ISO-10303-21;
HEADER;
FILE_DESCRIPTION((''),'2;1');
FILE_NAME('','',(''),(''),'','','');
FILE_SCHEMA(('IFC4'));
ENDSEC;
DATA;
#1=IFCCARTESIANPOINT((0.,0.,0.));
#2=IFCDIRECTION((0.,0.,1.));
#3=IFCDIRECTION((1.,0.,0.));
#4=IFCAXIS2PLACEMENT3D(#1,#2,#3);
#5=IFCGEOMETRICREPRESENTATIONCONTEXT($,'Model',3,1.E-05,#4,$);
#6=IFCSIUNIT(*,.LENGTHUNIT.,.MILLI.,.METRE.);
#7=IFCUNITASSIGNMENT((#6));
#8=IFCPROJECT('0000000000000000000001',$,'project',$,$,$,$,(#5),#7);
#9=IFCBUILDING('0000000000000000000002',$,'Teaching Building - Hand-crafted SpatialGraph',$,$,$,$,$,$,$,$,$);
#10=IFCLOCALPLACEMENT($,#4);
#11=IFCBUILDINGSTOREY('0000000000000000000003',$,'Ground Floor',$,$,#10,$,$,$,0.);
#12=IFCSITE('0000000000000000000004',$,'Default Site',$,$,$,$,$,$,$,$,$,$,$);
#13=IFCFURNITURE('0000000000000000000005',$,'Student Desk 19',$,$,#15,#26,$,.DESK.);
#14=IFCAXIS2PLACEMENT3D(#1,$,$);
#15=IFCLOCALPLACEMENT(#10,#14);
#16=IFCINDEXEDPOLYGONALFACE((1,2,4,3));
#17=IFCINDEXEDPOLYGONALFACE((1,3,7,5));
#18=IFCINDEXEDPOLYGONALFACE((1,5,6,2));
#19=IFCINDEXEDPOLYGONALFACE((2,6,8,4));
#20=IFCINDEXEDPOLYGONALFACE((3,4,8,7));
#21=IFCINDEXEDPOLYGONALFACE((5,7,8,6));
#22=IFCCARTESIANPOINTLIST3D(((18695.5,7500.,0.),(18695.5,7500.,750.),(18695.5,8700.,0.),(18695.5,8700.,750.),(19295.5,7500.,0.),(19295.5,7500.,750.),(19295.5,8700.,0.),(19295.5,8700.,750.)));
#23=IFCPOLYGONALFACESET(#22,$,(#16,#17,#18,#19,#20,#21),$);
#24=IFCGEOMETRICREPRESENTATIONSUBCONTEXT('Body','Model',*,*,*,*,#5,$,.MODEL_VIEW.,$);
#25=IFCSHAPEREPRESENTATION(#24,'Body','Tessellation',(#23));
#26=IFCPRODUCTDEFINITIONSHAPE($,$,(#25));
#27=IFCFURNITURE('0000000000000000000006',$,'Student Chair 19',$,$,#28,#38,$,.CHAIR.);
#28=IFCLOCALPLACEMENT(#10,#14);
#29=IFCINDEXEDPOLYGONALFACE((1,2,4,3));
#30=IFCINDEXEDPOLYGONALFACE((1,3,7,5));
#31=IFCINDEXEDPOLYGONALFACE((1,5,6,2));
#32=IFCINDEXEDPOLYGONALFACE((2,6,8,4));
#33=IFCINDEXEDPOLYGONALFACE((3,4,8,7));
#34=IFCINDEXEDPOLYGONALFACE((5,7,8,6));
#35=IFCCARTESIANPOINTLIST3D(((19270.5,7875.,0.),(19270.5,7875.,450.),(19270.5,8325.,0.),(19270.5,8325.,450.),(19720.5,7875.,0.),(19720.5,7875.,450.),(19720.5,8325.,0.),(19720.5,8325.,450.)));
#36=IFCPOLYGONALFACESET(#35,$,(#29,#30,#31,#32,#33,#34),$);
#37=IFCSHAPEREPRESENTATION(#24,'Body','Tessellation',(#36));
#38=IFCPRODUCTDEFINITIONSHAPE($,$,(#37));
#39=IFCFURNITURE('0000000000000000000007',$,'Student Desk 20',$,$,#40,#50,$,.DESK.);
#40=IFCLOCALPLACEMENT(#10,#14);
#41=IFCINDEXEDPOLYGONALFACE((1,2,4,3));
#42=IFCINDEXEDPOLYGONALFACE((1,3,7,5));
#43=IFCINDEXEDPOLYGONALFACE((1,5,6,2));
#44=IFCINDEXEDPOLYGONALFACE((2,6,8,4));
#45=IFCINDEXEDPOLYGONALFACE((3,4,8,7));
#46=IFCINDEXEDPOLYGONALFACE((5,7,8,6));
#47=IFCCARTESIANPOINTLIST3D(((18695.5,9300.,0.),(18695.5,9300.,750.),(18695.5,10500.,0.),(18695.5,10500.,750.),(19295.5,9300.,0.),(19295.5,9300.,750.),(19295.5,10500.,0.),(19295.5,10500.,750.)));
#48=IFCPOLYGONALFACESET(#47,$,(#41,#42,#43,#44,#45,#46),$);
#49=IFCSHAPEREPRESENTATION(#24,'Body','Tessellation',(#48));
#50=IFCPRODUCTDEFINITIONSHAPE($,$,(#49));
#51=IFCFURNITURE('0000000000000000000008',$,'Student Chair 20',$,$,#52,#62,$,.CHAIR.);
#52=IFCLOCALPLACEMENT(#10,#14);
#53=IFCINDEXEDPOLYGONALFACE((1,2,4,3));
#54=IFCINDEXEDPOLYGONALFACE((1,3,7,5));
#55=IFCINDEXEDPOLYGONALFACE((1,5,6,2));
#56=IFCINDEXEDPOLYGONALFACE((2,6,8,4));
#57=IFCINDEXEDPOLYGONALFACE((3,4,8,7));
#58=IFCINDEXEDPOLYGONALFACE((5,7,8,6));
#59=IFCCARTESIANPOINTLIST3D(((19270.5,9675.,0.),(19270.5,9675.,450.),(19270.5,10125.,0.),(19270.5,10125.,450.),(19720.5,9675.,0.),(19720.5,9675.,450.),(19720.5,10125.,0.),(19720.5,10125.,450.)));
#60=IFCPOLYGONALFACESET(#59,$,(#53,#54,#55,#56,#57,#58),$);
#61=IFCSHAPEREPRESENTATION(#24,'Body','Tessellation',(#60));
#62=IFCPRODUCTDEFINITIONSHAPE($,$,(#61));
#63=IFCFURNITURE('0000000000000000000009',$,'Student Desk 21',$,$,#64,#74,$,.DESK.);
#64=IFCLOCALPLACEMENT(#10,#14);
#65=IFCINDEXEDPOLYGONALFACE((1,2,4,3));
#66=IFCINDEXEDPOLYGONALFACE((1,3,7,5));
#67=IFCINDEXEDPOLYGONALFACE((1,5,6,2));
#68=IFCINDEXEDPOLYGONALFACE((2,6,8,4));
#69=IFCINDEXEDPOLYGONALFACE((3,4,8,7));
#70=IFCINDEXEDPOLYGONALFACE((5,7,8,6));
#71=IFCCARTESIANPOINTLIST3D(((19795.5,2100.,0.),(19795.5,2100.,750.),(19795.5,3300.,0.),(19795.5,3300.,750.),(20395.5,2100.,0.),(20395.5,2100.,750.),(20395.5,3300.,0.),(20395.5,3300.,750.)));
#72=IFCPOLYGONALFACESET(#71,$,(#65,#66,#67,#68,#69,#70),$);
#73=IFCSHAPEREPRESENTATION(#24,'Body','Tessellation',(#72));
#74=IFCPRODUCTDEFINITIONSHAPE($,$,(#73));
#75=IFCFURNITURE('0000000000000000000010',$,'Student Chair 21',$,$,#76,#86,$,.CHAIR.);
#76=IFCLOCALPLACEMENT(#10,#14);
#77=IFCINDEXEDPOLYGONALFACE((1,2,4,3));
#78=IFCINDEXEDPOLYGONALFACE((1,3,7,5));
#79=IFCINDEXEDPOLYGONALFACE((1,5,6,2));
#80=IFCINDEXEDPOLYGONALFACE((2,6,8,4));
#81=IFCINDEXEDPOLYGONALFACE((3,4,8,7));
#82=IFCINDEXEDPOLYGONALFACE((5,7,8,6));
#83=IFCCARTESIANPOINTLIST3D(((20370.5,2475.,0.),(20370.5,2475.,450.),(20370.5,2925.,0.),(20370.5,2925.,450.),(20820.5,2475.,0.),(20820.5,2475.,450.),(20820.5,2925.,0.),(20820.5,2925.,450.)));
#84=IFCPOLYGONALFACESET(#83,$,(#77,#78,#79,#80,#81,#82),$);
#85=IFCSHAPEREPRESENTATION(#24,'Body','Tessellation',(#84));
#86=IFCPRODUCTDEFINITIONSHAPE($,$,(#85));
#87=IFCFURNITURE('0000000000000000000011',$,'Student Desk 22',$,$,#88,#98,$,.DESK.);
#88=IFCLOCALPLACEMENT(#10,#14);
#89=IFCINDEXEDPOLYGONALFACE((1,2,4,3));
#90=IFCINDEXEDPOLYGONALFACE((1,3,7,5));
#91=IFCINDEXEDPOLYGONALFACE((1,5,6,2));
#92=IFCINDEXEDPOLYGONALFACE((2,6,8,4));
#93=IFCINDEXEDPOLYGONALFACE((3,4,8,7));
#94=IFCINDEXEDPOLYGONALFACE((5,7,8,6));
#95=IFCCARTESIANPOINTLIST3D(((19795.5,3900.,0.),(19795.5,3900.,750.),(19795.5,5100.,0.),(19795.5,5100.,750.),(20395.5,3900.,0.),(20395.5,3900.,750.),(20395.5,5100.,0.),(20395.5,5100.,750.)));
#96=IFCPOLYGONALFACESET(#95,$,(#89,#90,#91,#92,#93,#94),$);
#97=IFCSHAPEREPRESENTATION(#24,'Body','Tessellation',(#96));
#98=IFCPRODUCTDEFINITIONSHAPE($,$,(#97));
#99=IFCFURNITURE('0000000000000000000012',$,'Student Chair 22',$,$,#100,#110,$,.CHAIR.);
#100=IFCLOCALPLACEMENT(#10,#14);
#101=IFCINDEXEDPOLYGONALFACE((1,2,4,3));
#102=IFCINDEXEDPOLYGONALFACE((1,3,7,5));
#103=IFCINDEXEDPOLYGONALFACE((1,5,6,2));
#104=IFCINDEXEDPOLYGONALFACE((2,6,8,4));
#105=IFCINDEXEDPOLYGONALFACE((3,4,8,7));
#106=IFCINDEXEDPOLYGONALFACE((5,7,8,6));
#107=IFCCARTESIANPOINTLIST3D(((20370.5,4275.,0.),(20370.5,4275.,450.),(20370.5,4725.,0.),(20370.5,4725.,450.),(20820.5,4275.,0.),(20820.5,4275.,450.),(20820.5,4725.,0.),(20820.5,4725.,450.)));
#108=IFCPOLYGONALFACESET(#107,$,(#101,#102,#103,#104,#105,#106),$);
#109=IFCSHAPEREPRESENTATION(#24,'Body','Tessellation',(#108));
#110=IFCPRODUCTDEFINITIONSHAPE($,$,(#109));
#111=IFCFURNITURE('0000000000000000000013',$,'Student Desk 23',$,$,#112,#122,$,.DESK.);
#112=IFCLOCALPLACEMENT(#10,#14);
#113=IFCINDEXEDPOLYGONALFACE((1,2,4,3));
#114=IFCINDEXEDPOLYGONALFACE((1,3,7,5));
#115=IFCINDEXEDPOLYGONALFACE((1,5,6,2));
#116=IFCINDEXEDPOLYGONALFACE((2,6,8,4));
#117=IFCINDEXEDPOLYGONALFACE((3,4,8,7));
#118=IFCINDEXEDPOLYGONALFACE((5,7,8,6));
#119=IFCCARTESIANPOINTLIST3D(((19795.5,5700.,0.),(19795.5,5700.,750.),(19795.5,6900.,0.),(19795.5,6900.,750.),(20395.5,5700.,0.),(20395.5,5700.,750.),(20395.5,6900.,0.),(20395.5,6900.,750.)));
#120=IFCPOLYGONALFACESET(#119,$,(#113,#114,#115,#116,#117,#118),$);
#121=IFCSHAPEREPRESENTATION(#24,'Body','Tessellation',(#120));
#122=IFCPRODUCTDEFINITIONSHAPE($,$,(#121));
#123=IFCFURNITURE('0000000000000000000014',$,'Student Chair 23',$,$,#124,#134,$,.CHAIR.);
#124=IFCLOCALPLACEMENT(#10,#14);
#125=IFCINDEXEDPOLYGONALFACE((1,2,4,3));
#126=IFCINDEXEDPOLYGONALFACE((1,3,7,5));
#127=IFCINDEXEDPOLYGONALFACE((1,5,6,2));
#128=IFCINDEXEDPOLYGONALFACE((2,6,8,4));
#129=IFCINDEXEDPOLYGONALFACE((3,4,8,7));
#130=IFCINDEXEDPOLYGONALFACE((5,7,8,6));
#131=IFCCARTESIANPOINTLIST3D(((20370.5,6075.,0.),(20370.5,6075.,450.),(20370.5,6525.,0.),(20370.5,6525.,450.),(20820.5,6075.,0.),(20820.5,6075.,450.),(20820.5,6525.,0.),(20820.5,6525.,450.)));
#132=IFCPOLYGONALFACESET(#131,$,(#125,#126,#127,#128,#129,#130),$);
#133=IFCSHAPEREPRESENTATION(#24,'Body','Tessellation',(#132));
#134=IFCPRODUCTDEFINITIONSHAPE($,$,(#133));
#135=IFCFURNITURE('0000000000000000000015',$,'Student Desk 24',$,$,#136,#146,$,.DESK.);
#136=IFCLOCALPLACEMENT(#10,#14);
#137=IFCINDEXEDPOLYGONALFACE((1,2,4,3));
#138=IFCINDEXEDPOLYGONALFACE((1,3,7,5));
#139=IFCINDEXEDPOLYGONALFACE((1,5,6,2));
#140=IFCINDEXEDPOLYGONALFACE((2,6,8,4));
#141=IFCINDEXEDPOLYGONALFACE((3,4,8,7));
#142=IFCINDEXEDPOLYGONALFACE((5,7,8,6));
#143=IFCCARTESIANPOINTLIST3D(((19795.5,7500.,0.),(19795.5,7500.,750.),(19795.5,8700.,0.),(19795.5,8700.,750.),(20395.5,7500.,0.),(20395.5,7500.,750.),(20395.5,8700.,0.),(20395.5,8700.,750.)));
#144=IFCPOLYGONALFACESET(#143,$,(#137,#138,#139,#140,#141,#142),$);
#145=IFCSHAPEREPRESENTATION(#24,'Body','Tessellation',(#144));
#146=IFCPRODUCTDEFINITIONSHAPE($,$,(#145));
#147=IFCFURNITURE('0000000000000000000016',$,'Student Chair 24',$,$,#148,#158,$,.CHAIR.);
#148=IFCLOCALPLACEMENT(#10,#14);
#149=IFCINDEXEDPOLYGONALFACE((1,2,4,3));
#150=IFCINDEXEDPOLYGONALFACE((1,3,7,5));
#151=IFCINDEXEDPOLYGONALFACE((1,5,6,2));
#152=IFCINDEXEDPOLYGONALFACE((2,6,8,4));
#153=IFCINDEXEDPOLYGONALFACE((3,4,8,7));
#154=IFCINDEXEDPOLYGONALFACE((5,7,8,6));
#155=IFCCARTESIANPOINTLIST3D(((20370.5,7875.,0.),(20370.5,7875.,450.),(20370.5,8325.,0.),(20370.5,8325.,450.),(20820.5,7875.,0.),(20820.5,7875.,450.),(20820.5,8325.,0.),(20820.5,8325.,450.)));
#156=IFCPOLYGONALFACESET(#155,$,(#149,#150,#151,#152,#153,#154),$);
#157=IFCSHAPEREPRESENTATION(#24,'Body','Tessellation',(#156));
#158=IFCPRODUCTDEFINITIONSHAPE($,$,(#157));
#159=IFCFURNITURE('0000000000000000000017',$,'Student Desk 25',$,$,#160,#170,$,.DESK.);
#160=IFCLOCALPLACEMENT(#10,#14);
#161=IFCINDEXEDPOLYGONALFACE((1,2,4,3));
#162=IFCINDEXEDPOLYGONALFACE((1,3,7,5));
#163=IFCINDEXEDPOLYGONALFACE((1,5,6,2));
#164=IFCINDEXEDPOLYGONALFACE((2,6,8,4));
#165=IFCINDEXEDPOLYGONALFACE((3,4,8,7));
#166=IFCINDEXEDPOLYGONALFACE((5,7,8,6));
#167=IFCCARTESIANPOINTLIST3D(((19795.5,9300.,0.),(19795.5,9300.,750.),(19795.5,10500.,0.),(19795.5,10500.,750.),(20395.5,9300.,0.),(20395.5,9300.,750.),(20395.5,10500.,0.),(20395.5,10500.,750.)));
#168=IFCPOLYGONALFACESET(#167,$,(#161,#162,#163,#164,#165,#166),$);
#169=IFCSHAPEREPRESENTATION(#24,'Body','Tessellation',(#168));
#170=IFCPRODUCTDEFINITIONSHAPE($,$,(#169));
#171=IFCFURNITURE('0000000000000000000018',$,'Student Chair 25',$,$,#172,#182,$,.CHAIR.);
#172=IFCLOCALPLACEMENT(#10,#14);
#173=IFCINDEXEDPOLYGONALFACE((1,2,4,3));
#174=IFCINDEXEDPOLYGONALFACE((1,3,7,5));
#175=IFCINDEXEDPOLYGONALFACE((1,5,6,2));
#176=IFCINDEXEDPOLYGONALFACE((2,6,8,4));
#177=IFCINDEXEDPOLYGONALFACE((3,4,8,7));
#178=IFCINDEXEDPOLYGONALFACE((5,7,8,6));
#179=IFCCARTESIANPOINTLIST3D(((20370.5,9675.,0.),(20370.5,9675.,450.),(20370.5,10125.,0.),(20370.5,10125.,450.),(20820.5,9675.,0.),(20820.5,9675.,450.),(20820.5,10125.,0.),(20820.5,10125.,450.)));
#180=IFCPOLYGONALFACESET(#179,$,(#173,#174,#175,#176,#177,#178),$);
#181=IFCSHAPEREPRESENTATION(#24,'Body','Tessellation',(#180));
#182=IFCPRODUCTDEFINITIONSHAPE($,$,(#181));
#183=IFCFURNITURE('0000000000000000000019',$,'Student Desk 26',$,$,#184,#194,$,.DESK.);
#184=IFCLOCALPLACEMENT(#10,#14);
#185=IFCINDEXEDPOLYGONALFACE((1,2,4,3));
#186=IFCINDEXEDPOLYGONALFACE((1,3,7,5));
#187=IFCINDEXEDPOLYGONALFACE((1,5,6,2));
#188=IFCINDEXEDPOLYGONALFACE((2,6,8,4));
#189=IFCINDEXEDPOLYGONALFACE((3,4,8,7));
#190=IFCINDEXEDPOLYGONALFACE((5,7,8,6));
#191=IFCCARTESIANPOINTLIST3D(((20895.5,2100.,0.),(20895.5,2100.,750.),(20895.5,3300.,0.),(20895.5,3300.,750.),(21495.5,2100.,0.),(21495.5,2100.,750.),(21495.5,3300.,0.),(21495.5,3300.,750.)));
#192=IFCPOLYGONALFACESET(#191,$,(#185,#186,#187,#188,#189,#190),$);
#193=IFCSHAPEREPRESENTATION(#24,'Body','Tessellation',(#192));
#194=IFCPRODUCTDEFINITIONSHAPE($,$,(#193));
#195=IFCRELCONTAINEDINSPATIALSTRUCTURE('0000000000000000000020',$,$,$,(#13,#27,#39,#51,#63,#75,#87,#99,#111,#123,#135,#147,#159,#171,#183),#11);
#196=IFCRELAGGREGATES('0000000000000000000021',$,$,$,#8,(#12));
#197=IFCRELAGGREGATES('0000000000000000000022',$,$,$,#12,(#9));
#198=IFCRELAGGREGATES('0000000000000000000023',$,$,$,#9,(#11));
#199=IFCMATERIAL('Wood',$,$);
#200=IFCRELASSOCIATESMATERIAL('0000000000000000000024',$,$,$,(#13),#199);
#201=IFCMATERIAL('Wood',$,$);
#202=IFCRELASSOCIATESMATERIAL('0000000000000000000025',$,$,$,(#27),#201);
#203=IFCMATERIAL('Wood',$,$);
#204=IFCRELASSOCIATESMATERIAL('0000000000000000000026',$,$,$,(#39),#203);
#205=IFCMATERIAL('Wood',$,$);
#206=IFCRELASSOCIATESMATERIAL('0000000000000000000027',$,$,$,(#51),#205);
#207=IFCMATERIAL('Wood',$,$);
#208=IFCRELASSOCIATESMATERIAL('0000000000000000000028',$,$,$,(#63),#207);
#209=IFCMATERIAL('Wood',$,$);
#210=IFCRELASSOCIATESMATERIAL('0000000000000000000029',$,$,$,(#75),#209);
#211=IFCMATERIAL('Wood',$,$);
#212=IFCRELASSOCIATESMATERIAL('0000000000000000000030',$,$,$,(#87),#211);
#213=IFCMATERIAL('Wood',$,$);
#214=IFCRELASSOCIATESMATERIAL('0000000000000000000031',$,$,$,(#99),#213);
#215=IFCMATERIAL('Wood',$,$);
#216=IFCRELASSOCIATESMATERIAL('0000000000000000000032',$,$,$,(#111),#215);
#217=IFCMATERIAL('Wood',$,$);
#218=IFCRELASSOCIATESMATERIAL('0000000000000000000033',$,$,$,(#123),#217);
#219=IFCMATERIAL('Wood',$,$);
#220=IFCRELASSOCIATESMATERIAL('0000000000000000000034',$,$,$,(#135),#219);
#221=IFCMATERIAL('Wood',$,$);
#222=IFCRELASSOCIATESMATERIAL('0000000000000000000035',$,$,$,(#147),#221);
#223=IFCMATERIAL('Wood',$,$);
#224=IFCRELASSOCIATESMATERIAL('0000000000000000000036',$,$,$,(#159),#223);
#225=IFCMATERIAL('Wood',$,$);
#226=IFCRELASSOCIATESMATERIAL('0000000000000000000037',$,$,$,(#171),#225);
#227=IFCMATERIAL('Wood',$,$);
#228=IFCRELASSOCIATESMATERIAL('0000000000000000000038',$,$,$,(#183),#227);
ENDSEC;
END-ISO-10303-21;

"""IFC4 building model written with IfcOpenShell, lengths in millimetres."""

from ifc_helpers import new_model, si_unit, frame, origin_with_axes, origin_2d, place, context, subcontext, project, spatial, rectangle, extrude, material, element, save


model = new_model("IFC4")

# Units and contexts
model_context = context("Model", 3, precision=1e-05, world=origin_with_axes())
body_context = subcontext(model_context, "Body", "Model", "MODEL_VIEW")
ifc_project = project(units=[si_unit("LENGTHUNIT", "METRE", prefix="MILLI")], contexts=[model_context])

# Site, building, storey
site = spatial("IfcSite", under=ifc_project, Name="Default Site")
building = spatial("IfcBuilding", under=site, Name="Teaching Building - Hand-crafted SpatialGraph")
storey_placement = place(None, origin_with_axes())
storey = spatial("IfcBuildingStorey", under=building, at=storey_placement, Name="Ground Floor", Elevation=0.0)

# Furniture
ifc_material_1 = material(Name="Wood")
furniture_1_placement = place(storey_placement, frame((18995.5, 8100.0, 0.0), z_axis=(0.0, 0.0, 1.0), x_axis=(0.0, 1.0, 0.0)))
element("IfcFurniture", 1, at=furniture_1_placement, inside=storey, material=ifc_material_1, Name="Student Desk 19", PredefinedType="DESK", context=body_context, shape_type="SweptSolid", body=[
    extrude(rectangle(XDim=1200.0, YDim=600.0, at=origin_2d()), origin_with_axes(), (0.0, 0.0, 1.0), 750.0),
])
ifc_material_2 = material(Name="Wood")
furniture_2_placement = place(storey_placement, frame((19495.5, 8100.0, 0.0), z_axis=(0.0, 0.0, 1.0), x_axis=(1.0, 0.0, 0.0)))
element("IfcFurniture", 2, at=furniture_2_placement, inside=storey, material=ifc_material_2, Name="Student Chair 19", PredefinedType="CHAIR", context=body_context, shape_type="SweptSolid", body=[
    extrude(rectangle(XDim=450.0, YDim=450.0, at=origin_2d()), origin_with_axes(), (0.0, 0.0, 1.0), 450.0),
])
ifc_material_3 = material(Name="Wood")
furniture_3_placement = place(storey_placement, frame((18995.5, 9900.0, 0.0), z_axis=(0.0, 0.0, 1.0), x_axis=(0.0, 1.0, 0.0)))
element("IfcFurniture", 3, at=furniture_3_placement, inside=storey, material=ifc_material_3, Name="Student Desk 20", PredefinedType="DESK", context=body_context, shape_type="SweptSolid", body=[
    extrude(rectangle(XDim=1200.0, YDim=600.0, at=origin_2d()), origin_with_axes(), (0.0, 0.0, 1.0), 750.0),
])
ifc_material_4 = material(Name="Wood")
furniture_4_placement = place(storey_placement, frame((19495.5, 9900.0, 0.0), z_axis=(0.0, 0.0, 1.0), x_axis=(1.0, 0.0, 0.0)))
element("IfcFurniture", 4, at=furniture_4_placement, inside=storey, material=ifc_material_4, Name="Student Chair 20", PredefinedType="CHAIR", context=body_context, shape_type="SweptSolid", body=[
    extrude(rectangle(XDim=450.0, YDim=450.0, at=origin_2d()), origin_with_axes(), (0.0, 0.0, 1.0), 450.0),
])
ifc_material_5 = material(Name="Wood")
furniture_5_placement = place(storey_placement, frame((20095.5, 2700.0, 0.0), z_axis=(0.0, 0.0, 1.0), x_axis=(0.0, 1.0, 0.0)))
element("IfcFurniture", 5, at=furniture_5_placement, inside=storey, material=ifc_material_5, Name="Student Desk 21", PredefinedType="DESK", context=body_context, shape_type="SweptSolid", body=[
    extrude(rectangle(XDim=1200.0, YDim=600.0, at=origin_2d()), origin_with_axes(), (0.0, 0.0, 1.0), 750.0),
])
ifc_material_6 = material(Name="Wood")
furniture_6_placement = place(storey_placement, frame((20595.5, 2700.0, 0.0), z_axis=(0.0, 0.0, 1.0), x_axis=(1.0, 0.0, 0.0)))
element("IfcFurniture", 6, at=furniture_6_placement, inside=storey, material=ifc_material_6, Name="Student Chair 21", PredefinedType="CHAIR", context=body_context, shape_type="SweptSolid", body=[
    extrude(rectangle(XDim=450.0, YDim=450.0, at=origin_2d()), origin_with_axes(), (0.0, 0.0, 1.0), 450.0),
])
ifc_material_7 = material(Name="Wood")
furniture_7_placement = place(storey_placement, frame((20095.5, 4500.0, 0.0), z_axis=(0.0, 0.0, 1.0), x_axis=(0.0, 1.0, 0.0)))
element("IfcFurniture", 7, at=furniture_7_placement, inside=storey, material=ifc_material_7, Name="Student Desk 22", PredefinedType="DESK", context=body_context, shape_type="SweptSolid", body=[
    extrude(rectangle(XDim=1200.0, YDim=600.0, at=origin_2d()), origin_with_axes(), (0.0, 0.0, 1.0), 750.0),
])
ifc_material_8 = material(Name="Wood")
furniture_8_placement = place(storey_placement, frame((20595.5, 4500.0, 0.0), z_axis=(0.0, 0.0, 1.0), x_axis=(1.0, 0.0, 0.0)))
element("IfcFurniture", 8, at=furniture_8_placement, inside=storey, material=ifc_material_8, Name="Student Chair 22", PredefinedType="CHAIR", context=body_context, shape_type="SweptSolid", body=[
    extrude(rectangle(XDim=450.0, YDim=450.0, at=origin_2d()), origin_with_axes(), (0.0, 0.0, 1.0), 450.0),
])
ifc_material_9 = material(Name="Wood")
furniture_9_placement = place(storey_placement, frame((20095.5, 6300.0, 0.0), z_axis=(0.0, 0.0, 1.0), x_axis=(0.0, 1.0, 0.0)))
element("IfcFurniture", 9, at=furniture_9_placement, inside=storey, material=ifc_material_9, Name="Student Desk 23", PredefinedType="DESK", context=body_context, shape_type="SweptSolid", body=[
    extrude(rectangle(XDim=1200.0, YDim=600.0, at=origin_2d()), origin_with_axes(), (0.0, 0.0, 1.0), 750.0),
])
ifc_material_10 = material(Name="Wood")
furniture_10_placement = place(storey_placement, frame((20595.5, 6300.0, 0.0), z_axis=(0.0, 0.0, 1.0), x_axis=(1.0, 0.0, 0.0)))
element("IfcFurniture", 10, at=furniture_10_placement, inside=storey, material=ifc_material_10, Name="Student Chair 23", PredefinedType="CHAIR", context=body_context, shape_type="SweptSolid", body=[
    extrude(rectangle(XDim=450.0, YDim=450.0, at=origin_2d()), origin_with_axes(), (0.0, 0.0, 1.0), 450.0),
])
ifc_material_11 = material(Name="Wood")
furniture_11_placement = place(storey_placement, frame((20095.5, 8100.0, 0.0), z_axis=(0.0, 0.0, 1.0), x_axis=(0.0, 1.0, 0.0)))
element("IfcFurniture", 11, at=furniture_11_placement, inside=storey, material=ifc_material_11, Name="Student Desk 24", PredefinedType="DESK", context=body_context, shape_type="SweptSolid", body=[
    extrude(rectangle(XDim=1200.0, YDim=600.0, at=origin_2d()), origin_with_axes(), (0.0, 0.0, 1.0), 750.0),
])
ifc_material_12 = material(Name="Wood")
furniture_12_placement = place(storey_placement, frame((20595.5, 8100.0, 0.0), z_axis=(0.0, 0.0, 1.0), x_axis=(1.0, 0.0, 0.0)))
element("IfcFurniture", 12, at=furniture_12_placement, inside=storey, material=ifc_material_12, Name="Student Chair 24", PredefinedType="CHAIR", context=body_context, shape_type="SweptSolid", body=[
    extrude(rectangle(XDim=450.0, YDim=450.0, at=origin_2d()), origin_with_axes(), (0.0, 0.0, 1.0), 450.0),
])
ifc_material_13 = material(Name="Wood")
furniture_13_placement = place(storey_placement, frame((20095.5, 9900.0, 0.0), z_axis=(0.0, 0.0, 1.0), x_axis=(0.0, 1.0, 0.0)))
element("IfcFurniture", 13, at=furniture_13_placement, inside=storey, material=ifc_material_13, Name="Student Desk 25", PredefinedType="DESK", context=body_context, shape_type="SweptSolid", body=[
    extrude(rectangle(XDim=1200.0, YDim=600.0, at=origin_2d()), origin_with_axes(), (0.0, 0.0, 1.0), 750.0),
])
ifc_material_14 = material(Name="Wood")
furniture_14_placement = place(storey_placement, frame((20595.5, 9900.0, 0.0), z_axis=(0.0, 0.0, 1.0), x_axis=(1.0, 0.0, 0.0)))
element("IfcFurniture", 14, at=furniture_14_placement, inside=storey, material=ifc_material_14, Name="Student Chair 25", PredefinedType="CHAIR", context=body_context, shape_type="SweptSolid", body=[
    extrude(rectangle(XDim=450.0, YDim=450.0, at=origin_2d()), origin_with_axes(), (0.0, 0.0, 1.0), 450.0),
])
ifc_material_15 = material(Name="Wood")
furniture_15_placement = place(storey_placement, frame((21195.5, 2700.0, 0.0), z_axis=(0.0, 0.0, 1.0), x_axis=(0.0, 1.0, 0.0)))
element("IfcFurniture", 15, at=furniture_15_placement, inside=storey, material=ifc_material_15, Name="Student Desk 26", PredefinedType="DESK", context=body_context, shape_type="SweptSolid", body=[
    extrude(rectangle(XDim=1200.0, YDim=600.0, at=origin_2d()), origin_with_axes(), (0.0, 0.0, 1.0), 750.0),
])

save(model, "model.ifc")
